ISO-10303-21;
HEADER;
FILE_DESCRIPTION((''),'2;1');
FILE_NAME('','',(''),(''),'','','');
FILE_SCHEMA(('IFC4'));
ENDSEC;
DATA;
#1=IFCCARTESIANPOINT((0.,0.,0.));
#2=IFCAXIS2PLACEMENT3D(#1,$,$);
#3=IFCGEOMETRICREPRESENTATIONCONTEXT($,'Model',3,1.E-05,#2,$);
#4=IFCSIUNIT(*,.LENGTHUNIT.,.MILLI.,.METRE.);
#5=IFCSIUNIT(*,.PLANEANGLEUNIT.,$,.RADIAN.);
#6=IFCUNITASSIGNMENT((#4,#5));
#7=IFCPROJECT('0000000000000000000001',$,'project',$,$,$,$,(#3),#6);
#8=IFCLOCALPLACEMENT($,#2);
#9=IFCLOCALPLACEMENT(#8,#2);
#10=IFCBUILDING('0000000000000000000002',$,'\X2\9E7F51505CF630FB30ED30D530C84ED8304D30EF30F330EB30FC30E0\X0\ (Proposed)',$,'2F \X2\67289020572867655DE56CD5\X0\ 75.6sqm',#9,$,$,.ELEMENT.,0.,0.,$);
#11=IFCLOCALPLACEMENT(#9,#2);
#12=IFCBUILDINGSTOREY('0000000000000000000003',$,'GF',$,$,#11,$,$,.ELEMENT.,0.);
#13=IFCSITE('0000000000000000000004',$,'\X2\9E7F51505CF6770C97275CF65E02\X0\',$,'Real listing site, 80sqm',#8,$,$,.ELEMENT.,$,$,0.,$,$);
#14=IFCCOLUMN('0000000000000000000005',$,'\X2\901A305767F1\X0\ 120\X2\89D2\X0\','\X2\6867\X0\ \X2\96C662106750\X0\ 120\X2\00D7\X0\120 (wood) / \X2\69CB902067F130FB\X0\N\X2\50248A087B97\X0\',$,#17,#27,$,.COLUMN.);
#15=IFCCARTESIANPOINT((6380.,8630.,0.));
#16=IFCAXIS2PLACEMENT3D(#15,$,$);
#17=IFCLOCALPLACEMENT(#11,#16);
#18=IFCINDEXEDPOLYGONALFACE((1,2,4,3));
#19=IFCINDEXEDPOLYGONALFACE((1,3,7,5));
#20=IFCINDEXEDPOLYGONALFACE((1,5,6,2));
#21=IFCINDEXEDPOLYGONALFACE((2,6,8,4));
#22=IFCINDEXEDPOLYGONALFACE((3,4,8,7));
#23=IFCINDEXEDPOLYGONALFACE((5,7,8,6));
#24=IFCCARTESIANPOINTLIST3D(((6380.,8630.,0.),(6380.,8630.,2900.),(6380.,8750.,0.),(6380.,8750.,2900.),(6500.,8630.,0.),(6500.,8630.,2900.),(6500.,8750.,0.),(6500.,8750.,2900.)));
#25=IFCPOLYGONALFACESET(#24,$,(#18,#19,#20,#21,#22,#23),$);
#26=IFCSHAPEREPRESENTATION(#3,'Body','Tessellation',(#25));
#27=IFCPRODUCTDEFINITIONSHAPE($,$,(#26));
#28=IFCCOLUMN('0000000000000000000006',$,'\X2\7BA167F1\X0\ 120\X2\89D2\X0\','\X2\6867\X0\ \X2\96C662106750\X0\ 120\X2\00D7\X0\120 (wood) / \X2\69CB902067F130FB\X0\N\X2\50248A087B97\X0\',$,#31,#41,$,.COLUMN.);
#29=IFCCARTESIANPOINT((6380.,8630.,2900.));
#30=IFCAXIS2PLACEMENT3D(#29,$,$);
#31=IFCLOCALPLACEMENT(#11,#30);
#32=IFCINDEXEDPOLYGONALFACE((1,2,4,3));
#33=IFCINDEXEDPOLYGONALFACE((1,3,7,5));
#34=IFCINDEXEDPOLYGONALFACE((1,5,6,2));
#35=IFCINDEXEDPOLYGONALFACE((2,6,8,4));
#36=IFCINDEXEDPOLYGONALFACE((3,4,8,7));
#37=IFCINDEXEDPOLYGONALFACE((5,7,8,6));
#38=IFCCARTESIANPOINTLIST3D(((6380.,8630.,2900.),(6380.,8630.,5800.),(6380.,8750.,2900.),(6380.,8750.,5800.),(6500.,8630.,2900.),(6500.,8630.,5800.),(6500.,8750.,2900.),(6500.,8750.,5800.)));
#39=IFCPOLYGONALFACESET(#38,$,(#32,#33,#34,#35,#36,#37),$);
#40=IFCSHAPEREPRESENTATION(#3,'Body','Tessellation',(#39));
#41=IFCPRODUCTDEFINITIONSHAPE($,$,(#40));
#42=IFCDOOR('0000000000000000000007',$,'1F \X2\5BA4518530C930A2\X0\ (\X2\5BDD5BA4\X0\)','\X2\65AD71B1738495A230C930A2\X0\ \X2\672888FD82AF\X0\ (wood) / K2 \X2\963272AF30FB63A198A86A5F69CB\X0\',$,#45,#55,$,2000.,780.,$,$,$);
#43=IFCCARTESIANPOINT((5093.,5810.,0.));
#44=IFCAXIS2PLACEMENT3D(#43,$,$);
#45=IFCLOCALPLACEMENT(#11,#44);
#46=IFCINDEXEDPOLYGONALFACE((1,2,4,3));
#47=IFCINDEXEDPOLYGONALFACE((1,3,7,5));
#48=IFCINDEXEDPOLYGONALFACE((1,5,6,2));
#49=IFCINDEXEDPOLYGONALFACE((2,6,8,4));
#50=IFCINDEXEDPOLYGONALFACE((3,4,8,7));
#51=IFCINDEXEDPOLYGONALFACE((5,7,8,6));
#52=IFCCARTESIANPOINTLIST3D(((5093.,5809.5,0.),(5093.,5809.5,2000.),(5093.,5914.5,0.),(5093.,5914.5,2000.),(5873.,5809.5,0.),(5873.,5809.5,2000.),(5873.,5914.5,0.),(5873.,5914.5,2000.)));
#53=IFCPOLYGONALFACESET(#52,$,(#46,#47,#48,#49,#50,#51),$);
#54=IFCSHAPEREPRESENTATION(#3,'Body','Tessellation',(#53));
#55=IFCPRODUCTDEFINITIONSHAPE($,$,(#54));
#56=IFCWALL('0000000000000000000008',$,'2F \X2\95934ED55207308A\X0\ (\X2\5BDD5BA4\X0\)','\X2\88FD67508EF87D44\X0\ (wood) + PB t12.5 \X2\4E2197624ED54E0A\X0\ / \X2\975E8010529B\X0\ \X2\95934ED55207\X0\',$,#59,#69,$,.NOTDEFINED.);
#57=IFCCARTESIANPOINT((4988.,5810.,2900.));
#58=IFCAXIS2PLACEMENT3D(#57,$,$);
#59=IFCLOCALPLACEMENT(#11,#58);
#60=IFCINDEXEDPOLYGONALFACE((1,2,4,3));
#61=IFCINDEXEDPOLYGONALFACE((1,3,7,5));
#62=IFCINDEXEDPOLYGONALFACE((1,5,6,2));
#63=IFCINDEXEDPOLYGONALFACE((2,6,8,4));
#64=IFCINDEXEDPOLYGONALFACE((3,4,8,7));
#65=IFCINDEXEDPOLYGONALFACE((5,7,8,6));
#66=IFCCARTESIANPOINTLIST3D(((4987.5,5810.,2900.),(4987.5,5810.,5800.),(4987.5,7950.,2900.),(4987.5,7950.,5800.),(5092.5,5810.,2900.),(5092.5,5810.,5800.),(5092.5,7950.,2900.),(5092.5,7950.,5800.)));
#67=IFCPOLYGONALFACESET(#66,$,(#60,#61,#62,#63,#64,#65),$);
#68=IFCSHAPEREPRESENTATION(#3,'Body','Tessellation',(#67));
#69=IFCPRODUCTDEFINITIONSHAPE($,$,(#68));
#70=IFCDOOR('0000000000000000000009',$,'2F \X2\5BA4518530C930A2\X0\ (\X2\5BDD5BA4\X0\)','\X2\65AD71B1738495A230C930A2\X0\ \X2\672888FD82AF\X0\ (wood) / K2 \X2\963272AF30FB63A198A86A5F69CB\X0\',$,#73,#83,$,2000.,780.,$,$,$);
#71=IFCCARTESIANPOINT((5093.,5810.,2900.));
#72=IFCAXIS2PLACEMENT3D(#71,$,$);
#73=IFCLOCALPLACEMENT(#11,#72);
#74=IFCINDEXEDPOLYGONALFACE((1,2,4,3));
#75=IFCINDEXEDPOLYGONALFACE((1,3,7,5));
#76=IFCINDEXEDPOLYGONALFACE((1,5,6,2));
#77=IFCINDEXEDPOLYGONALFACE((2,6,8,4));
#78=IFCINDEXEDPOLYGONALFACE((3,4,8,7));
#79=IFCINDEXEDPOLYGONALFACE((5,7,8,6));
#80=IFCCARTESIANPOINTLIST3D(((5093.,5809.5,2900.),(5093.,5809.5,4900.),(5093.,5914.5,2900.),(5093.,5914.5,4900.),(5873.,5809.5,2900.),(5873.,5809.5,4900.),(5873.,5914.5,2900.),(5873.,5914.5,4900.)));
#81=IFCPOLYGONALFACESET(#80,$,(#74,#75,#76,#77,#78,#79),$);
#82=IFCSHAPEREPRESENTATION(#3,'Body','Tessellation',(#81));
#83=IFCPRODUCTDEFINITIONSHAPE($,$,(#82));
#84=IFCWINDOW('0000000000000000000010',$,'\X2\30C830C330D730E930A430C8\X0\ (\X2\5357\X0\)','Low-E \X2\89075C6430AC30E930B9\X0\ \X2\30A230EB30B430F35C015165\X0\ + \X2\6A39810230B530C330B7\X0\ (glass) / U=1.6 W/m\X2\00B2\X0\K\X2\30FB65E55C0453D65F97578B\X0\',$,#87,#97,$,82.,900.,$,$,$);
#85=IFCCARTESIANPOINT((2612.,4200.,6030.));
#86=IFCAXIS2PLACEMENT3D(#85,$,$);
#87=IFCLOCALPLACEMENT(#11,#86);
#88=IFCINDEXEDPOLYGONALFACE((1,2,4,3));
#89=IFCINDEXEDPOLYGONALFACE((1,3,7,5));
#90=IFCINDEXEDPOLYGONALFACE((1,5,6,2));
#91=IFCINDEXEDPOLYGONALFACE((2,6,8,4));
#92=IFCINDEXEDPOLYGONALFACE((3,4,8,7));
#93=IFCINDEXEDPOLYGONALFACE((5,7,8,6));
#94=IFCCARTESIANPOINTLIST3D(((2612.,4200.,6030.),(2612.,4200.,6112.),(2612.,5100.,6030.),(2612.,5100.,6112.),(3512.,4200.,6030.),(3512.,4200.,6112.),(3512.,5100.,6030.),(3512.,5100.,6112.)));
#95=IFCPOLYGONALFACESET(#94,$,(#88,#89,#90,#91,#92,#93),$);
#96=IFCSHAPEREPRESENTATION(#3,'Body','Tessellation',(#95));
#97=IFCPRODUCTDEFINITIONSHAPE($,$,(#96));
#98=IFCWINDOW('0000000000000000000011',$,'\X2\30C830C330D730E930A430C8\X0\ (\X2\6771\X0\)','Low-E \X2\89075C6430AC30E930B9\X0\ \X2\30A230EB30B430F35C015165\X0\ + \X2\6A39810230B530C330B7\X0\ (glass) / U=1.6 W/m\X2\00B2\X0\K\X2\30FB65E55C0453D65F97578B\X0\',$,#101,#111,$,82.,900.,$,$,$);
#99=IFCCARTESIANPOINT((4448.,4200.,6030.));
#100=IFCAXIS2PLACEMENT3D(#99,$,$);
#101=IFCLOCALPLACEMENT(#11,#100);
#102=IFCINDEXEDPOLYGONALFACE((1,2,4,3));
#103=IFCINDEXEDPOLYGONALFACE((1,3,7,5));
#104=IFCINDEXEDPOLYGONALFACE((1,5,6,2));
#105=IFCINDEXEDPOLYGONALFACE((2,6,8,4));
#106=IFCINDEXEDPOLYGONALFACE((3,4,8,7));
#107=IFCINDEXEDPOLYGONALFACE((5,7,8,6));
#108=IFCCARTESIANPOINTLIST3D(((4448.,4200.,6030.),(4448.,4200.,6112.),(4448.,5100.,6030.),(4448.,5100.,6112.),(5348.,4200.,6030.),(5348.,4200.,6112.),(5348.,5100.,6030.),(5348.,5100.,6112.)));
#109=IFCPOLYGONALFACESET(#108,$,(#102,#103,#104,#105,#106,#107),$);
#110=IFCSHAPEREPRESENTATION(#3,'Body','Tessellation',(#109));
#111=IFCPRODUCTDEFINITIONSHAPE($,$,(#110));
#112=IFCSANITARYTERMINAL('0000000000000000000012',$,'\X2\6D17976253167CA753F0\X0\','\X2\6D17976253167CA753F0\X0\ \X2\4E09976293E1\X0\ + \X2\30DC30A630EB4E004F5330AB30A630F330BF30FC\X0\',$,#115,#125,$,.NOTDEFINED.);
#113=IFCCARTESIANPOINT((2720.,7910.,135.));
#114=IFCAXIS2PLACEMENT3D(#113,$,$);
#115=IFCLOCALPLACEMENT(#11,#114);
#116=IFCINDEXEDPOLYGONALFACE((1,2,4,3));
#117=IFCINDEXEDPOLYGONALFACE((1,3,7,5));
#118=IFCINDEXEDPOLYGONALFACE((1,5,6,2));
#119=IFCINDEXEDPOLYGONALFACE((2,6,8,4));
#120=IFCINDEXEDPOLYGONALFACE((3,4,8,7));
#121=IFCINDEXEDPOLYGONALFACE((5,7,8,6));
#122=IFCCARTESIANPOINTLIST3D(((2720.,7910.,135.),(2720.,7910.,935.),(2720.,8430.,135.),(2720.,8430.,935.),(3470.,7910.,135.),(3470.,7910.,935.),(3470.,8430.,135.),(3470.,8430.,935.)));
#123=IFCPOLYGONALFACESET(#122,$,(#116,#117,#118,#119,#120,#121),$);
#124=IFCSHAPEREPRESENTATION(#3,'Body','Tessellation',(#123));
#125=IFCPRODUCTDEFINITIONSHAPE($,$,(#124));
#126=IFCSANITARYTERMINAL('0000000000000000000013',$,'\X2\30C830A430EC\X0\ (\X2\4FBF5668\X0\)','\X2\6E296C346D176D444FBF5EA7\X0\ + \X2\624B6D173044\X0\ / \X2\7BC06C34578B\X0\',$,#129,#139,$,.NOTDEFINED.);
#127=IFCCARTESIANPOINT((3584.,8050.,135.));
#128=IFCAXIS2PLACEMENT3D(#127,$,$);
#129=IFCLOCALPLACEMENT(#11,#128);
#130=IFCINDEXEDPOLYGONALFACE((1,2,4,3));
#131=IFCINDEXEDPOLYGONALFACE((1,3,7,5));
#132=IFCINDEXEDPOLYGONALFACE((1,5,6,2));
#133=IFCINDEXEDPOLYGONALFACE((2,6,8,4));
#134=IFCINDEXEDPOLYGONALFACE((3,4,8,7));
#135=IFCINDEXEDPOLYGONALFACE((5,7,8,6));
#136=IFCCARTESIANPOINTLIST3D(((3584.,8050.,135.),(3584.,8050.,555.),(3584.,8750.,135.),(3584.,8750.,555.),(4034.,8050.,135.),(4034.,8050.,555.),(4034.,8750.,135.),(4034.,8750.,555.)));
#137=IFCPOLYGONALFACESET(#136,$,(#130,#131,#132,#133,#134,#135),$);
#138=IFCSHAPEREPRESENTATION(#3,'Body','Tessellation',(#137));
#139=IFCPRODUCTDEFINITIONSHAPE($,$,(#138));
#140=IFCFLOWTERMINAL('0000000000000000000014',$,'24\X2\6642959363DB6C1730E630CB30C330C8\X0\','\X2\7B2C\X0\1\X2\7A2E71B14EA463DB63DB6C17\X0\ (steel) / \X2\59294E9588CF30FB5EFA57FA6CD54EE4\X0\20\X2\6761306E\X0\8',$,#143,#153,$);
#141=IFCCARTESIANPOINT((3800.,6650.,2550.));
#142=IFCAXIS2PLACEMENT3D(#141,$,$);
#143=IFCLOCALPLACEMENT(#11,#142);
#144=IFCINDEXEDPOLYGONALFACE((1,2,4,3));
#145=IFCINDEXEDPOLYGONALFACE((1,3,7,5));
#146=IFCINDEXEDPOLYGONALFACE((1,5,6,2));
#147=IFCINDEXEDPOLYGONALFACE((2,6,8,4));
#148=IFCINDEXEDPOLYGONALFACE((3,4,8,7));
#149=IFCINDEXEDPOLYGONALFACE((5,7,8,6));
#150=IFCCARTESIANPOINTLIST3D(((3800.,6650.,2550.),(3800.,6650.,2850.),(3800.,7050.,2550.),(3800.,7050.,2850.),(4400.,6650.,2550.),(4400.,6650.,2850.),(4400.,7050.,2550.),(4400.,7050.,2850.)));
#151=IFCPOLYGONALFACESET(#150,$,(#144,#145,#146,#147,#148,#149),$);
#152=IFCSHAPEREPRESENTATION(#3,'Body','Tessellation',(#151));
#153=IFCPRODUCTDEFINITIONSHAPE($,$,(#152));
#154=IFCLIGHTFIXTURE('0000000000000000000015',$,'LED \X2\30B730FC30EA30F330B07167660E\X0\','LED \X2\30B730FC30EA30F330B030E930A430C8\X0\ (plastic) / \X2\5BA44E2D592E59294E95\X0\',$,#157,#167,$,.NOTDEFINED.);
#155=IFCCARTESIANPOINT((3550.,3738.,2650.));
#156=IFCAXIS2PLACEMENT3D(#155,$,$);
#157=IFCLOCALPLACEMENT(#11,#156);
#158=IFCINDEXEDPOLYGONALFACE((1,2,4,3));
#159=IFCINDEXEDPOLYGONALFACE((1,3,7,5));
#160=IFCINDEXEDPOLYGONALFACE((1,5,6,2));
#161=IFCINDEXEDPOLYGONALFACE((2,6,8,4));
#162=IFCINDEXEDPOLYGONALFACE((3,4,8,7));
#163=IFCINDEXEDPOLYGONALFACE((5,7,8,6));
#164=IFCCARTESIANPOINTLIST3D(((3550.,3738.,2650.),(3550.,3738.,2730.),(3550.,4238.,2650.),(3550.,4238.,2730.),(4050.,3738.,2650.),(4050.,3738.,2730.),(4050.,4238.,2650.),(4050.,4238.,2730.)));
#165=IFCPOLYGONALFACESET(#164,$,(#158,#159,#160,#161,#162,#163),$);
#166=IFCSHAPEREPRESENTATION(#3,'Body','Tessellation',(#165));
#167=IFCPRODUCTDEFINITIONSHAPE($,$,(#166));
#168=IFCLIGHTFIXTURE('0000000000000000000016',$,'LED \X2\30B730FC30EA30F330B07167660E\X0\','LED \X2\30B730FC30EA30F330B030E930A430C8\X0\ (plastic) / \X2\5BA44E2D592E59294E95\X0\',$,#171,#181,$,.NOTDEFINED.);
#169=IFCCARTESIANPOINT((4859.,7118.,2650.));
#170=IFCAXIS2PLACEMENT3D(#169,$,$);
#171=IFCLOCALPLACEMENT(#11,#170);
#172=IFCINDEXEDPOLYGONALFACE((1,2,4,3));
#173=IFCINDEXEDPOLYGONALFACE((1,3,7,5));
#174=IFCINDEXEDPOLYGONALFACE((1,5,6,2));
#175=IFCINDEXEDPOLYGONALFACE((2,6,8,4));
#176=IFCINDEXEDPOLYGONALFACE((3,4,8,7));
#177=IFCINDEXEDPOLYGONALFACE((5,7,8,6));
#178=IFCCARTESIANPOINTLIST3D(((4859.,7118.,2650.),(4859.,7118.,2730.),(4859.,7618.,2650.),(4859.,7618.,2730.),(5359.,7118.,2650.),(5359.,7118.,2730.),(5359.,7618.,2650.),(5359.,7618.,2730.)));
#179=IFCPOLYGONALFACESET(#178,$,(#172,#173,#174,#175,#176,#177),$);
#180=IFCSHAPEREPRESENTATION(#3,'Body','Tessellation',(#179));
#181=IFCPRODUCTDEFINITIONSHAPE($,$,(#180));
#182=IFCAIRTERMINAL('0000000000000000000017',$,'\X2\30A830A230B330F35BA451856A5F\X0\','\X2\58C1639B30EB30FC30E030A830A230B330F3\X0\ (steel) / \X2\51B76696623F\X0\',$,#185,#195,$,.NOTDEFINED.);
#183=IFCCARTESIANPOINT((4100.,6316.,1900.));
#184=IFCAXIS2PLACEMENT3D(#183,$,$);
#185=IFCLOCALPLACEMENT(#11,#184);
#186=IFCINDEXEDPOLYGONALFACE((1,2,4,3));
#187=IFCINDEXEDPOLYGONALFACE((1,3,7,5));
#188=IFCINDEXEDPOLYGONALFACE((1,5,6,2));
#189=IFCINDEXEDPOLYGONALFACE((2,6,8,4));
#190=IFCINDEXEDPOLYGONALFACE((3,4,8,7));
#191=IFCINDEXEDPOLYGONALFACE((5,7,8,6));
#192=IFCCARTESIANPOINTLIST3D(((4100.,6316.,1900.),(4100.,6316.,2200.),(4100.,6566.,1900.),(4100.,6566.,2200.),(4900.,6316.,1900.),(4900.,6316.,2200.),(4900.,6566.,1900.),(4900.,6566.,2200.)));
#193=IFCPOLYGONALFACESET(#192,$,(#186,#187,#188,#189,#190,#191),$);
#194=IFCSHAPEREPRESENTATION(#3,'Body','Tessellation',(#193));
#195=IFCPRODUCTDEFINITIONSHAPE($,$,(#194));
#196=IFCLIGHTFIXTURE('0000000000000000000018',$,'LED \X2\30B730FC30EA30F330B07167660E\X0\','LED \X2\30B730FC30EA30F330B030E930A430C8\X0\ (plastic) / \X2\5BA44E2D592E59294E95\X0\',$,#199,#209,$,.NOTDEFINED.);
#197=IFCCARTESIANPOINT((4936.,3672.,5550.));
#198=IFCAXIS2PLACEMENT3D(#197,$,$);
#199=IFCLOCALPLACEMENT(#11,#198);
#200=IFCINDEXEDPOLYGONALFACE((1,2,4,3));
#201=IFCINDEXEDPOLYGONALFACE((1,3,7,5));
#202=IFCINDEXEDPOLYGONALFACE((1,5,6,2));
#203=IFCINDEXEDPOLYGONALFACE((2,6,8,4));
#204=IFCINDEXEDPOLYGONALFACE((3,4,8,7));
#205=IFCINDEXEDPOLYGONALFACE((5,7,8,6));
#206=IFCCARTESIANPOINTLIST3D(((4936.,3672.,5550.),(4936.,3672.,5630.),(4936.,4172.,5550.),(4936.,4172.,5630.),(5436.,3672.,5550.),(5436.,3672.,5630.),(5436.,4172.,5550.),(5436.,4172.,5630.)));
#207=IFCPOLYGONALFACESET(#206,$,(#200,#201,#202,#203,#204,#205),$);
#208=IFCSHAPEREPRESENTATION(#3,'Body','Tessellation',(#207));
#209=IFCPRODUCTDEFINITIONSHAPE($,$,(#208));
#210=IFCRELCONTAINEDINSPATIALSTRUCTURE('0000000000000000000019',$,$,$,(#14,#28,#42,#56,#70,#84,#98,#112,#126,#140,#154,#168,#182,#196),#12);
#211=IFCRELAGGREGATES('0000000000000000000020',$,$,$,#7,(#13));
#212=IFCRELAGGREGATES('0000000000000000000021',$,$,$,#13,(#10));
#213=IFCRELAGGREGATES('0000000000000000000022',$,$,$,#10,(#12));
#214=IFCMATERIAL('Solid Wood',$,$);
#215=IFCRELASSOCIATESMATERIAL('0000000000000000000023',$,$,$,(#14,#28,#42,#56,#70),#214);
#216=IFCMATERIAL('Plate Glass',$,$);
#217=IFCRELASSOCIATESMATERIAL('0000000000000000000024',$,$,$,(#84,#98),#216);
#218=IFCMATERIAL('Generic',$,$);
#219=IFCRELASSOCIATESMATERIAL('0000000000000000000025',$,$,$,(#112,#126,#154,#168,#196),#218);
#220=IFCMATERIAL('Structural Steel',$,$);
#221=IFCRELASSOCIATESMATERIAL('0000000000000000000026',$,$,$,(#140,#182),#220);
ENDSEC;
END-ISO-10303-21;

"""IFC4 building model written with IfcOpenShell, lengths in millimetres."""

from ifc_helpers import new_model, si_unit, frame, frame_2d, origin, place, context, project, spatial, rectangle, extrude, material, element, save


model = new_model("IFC4")

# Units and contexts
model_context = context("Model", 3, precision=1e-05, world=origin())
ifc_project = project(units=[si_unit("LENGTHUNIT", "METRE", prefix="MILLI"), si_unit("PLANEANGLEUNIT", "RADIAN")], contexts=[model_context])

# Site, building, storey
site_placement = place(None, origin())
site = spatial("IfcSite", under=ifc_project, at=site_placement, Name="鹿児島県霧島市", ObjectType="Real listing site, 80sqm", CompositionType="ELEMENT", RefElevation=0.0)
building_placement = place(site_placement, origin())
building = spatial("IfcBuilding", under=site, at=building_placement, Name="鹿児島・ロフト付きワンルーム (Proposed)", ObjectType="2F 木造在来工法 75.6sqm", CompositionType="ELEMENT", ElevationOfRefHeight=0.0, ElevationOfTerrain=0.0)
storey_placement = place(building_placement, origin())
storey = spatial("IfcBuildingStorey", under=building, at=storey_placement, Name="GF", CompositionType="ELEMENT", Elevation=0.0)

# Columns
ifc_material_1 = material(Name="Solid Wood")
column_1_placement = place(storey_placement, frame((6380.0, 8630.0, 0.0)))
element("IfcColumn", 1, at=column_1_placement, inside=storey, material=ifc_material_1, Name="通し柱 120角", Description="桧 集成材 120×120 (wood) / 構造柱・N値計算", PredefinedType="COLUMN", context=model_context, shape_type="SweptSolid", body=[
    extrude(rectangle(XDim=120.0, YDim=120.0, at=frame_2d((60.0, 60.0))), frame((6380.0, 8630.0, 0.0)), (0.0, 0.0, 1.0), 2900.0),
])
column_2_placement = place(storey_placement, frame((6380.0, 8630.0, 2900.0)))
element("IfcColumn", 2, at=column_2_placement, inside=storey, material=ifc_material_1, Name="管柱 120角", Description="桧 集成材 120×120 (wood) / 構造柱・N値計算", PredefinedType="COLUMN", context=model_context, shape_type="SweptSolid", body=[
    extrude(rectangle(XDim=120.0, YDim=120.0, at=frame_2d((60.0, 60.0))), frame((6380.0, 8630.0, 2900.0)), (0.0, 0.0, 1.0), 2900.0),
])

# Door
door_1_placement = place(storey_placement, frame((5093.0, 5810.0, 0.0)))
element("IfcDoor", 3, at=door_1_placement, inside=storey, material=ifc_material_1, Name="1F 室内ドア (寝室)", Description="断熱玄関ドア 木製芯 (wood) / K2 防犯・採風機構", OverallHeight=2000.0, OverallWidth=780.0, context=model_context, shape_type="SweptSolid", body=[
    extrude(rectangle(XDim=780.0, YDim=105.0, at=frame_2d((390.0, 52.0))), frame((5093.0, 5810.0, 0.0)), (0.0, 0.0, 1.0), 2000.0),
])

# Wall
wall_1_placement = place(storey_placement, frame((4988.0, 5810.0, 2900.0)))
element("IfcWall", 4, at=wall_1_placement, inside=storey, material=ifc_material_1, Name="2F 間仕切り (寝室)", Description="製材軸組 (wood) + PB t12.5 両面仕上 / 非耐力 間仕切", PredefinedType="NOTDEFINED", context=model_context, shape_type="SweptSolid", body=[
    extrude(rectangle(XDim=105.0, YDim=2140.0, at=frame_2d((52.0, 1070.0))), frame((4988.0, 5810.0, 2900.0)), (0.0, 0.0, 1.0), 2900.0),
])

# Door
door_2_placement = place(storey_placement, frame((5093.0, 5810.0, 2900.0)))
element("IfcDoor", 5, at=door_2_placement, inside=storey, material=ifc_material_1, Name="2F 室内ドア (寝室)", Description="断熱玄関ドア 木製芯 (wood) / K2 防犯・採風機構", OverallHeight=2000.0, OverallWidth=780.0, context=model_context, shape_type="SweptSolid", body=[
    extrude(rectangle(XDim=780.0, YDim=105.0, at=frame_2d((390.0, 52.0))), frame((5093.0, 5810.0, 2900.0)), (0.0, 0.0, 1.0), 2000.0),
])

# Windows
ifc_material_2 = material(Name="Plate Glass")
window_1_placement = place(storey_placement, frame((2612.0, 4200.0, 6030.0)))
element("IfcWindow", 6, at=window_1_placement, inside=storey, material=ifc_material_2, Name="トップライト (南)", Description="Low-E 複層ガラス アルゴン封入 + 樹脂サッシ (glass) / U=1.6 W/m²K・日射取得型", OverallHeight=82.0, OverallWidth=900.0, context=model_context, shape_type="SweptSolid", body=[
    extrude(rectangle(XDim=900.0, YDim=900.0, at=frame_2d((450.0, 450.0))), frame((2612.0, 4200.0, 6030.0)), (0.0, 0.0, 1.0), 82.0),
])
window_2_placement = place(storey_placement, frame((4448.0, 4200.0, 6030.0)))
element("IfcWindow", 7, at=window_2_placement, inside=storey, material=ifc_material_2, Name="トップライト (東)", Description="Low-E 複層ガラス アルゴン封入 + 樹脂サッシ (glass) / U=1.6 W/m²K・日射取得型", OverallHeight=82.0, OverallWidth=900.0, context=model_context, shape_type="SweptSolid", body=[
    extrude(rectangle(XDim=900.0, YDim=900.0, at=frame_2d((450.0, 450.0))), frame((4448.0, 4200.0, 6030.0)), (0.0, 0.0, 1.0), 82.0),
])

# Sanitary terminals
ifc_material_3 = material(Name="Generic")
sanitary_terminal_1_placement = place(storey_placement, frame((2720.0, 7910.0, 135.0)))
element("IfcSanitaryTerminal", 8, at=sanitary_terminal_1_placement, inside=storey, material=ifc_material_3, Name="洗面化粧台", Description="洗面化粧台 三面鏡 + ボウル一体カウンター", PredefinedType="NOTDEFINED", context=model_context, shape_type="SweptSolid", body=[
    extrude(rectangle(XDim=750.0, YDim=520.0, at=frame_2d((375.0, 260.0))), frame((2720.0, 7910.0, 135.0)), (0.0, 0.0, 1.0), 800.0),
])
sanitary_terminal_2_placement = place(storey_placement, frame((3584.0, 8050.0, 135.0)))
element("IfcSanitaryTerminal", 9, at=sanitary_terminal_2_placement, inside=storey, material=ifc_material_3, Name="トイレ (便器)", Description="温水洗浄便座 + 手洗い / 節水型", PredefinedType="NOTDEFINED", context=model_context, shape_type="SweptSolid", body=[
    extrude(rectangle(XDim=450.0, YDim=700.0, at=frame_2d((225.0, 350.0))), frame((3584.0, 8050.0, 135.0)), (0.0, 0.0, 1.0), 420.0),
])

# Flow terminal
ifc_material_4 = material(Name="Structural Steel")
flow_terminal_placement = place(storey_placement, frame((3800.0, 6650.0, 2550.0)))
element("IfcFlowTerminal", 10, at=flow_terminal_placement, inside=storey, material=ifc_material_4, Name="24時間換気ユニット", Description="第1種熱交換換気 (steel) / 天井裏・建基法令20条の8", context=model_context, shape_type="SweptSolid", body=[
    extrude(rectangle(XDim=600.0, YDim=400.0, at=frame_2d((300.0, 200.0))), frame((3800.0, 6650.0, 2550.0)), (0.0, 0.0, 1.0), 300.0),
])

# Light fixtures
light_fixture_1_placement = place(storey_placement, frame((3550.0, 3738.0, 2650.0)))
element("IfcLightFixture", 11, at=light_fixture_1_placement, inside=storey, material=ifc_material_3, Name="LED シーリング照明", Description="LED シーリングライト (plastic) / 室中央天井", PredefinedType="NOTDEFINED", context=model_context, shape_type="SweptSolid", body=[
    extrude(rectangle(XDim=500.0, YDim=500.0, at=frame_2d((250.0, 250.0))), frame((3550.0, 3738.0, 2650.0)), (0.0, 0.0, 1.0), 80.0),
])
light_fixture_2_placement = place(storey_placement, frame((4859.0, 7118.0, 2650.0)))
element("IfcLightFixture", 12, at=light_fixture_2_placement, inside=storey, material=ifc_material_3, Name="LED シーリング照明", Description="LED シーリングライト (plastic) / 室中央天井", PredefinedType="NOTDEFINED", context=model_context, shape_type="SweptSolid", body=[
    extrude(rectangle(XDim=500.0, YDim=500.0, at=frame_2d((250.0, 250.0))), frame((4859.0, 7118.0, 2650.0)), (0.0, 0.0, 1.0), 80.0),
])

# Air terminal
air_terminal_placement = place(storey_placement, frame((4100.0, 6316.0, 1900.0)))
element("IfcAirTerminal", 13, at=air_terminal_placement, inside=storey, material=ifc_material_4, Name="エアコン室内機", Description="壁掛ルームエアコン (steel) / 冷暖房", PredefinedType="NOTDEFINED", context=model_context, shape_type="SweptSolid", body=[
    extrude(rectangle(XDim=800.0, YDim=250.0, at=frame_2d((400.0, 125.0))), frame((4100.0, 6316.0, 1900.0)), (0.0, 0.0, 1.0), 300.0),
])

# Light fixture
light_fixture_3_placement = place(storey_placement, frame((4936.0, 3672.0, 5550.0)))
element("IfcLightFixture", 14, at=light_fixture_3_placement, inside=storey, material=ifc_material_3, Name="LED シーリング照明", Description="LED シーリングライト (plastic) / 室中央天井", PredefinedType="NOTDEFINED", context=model_context, shape_type="SweptSolid", body=[
    extrude(rectangle(XDim=500.0, YDim=500.0, at=frame_2d((250.0, 250.0))), frame((4936.0, 3672.0, 5550.0)), (0.0, 0.0, 1.0), 80.0),
])

save(model, "model.ifc")
